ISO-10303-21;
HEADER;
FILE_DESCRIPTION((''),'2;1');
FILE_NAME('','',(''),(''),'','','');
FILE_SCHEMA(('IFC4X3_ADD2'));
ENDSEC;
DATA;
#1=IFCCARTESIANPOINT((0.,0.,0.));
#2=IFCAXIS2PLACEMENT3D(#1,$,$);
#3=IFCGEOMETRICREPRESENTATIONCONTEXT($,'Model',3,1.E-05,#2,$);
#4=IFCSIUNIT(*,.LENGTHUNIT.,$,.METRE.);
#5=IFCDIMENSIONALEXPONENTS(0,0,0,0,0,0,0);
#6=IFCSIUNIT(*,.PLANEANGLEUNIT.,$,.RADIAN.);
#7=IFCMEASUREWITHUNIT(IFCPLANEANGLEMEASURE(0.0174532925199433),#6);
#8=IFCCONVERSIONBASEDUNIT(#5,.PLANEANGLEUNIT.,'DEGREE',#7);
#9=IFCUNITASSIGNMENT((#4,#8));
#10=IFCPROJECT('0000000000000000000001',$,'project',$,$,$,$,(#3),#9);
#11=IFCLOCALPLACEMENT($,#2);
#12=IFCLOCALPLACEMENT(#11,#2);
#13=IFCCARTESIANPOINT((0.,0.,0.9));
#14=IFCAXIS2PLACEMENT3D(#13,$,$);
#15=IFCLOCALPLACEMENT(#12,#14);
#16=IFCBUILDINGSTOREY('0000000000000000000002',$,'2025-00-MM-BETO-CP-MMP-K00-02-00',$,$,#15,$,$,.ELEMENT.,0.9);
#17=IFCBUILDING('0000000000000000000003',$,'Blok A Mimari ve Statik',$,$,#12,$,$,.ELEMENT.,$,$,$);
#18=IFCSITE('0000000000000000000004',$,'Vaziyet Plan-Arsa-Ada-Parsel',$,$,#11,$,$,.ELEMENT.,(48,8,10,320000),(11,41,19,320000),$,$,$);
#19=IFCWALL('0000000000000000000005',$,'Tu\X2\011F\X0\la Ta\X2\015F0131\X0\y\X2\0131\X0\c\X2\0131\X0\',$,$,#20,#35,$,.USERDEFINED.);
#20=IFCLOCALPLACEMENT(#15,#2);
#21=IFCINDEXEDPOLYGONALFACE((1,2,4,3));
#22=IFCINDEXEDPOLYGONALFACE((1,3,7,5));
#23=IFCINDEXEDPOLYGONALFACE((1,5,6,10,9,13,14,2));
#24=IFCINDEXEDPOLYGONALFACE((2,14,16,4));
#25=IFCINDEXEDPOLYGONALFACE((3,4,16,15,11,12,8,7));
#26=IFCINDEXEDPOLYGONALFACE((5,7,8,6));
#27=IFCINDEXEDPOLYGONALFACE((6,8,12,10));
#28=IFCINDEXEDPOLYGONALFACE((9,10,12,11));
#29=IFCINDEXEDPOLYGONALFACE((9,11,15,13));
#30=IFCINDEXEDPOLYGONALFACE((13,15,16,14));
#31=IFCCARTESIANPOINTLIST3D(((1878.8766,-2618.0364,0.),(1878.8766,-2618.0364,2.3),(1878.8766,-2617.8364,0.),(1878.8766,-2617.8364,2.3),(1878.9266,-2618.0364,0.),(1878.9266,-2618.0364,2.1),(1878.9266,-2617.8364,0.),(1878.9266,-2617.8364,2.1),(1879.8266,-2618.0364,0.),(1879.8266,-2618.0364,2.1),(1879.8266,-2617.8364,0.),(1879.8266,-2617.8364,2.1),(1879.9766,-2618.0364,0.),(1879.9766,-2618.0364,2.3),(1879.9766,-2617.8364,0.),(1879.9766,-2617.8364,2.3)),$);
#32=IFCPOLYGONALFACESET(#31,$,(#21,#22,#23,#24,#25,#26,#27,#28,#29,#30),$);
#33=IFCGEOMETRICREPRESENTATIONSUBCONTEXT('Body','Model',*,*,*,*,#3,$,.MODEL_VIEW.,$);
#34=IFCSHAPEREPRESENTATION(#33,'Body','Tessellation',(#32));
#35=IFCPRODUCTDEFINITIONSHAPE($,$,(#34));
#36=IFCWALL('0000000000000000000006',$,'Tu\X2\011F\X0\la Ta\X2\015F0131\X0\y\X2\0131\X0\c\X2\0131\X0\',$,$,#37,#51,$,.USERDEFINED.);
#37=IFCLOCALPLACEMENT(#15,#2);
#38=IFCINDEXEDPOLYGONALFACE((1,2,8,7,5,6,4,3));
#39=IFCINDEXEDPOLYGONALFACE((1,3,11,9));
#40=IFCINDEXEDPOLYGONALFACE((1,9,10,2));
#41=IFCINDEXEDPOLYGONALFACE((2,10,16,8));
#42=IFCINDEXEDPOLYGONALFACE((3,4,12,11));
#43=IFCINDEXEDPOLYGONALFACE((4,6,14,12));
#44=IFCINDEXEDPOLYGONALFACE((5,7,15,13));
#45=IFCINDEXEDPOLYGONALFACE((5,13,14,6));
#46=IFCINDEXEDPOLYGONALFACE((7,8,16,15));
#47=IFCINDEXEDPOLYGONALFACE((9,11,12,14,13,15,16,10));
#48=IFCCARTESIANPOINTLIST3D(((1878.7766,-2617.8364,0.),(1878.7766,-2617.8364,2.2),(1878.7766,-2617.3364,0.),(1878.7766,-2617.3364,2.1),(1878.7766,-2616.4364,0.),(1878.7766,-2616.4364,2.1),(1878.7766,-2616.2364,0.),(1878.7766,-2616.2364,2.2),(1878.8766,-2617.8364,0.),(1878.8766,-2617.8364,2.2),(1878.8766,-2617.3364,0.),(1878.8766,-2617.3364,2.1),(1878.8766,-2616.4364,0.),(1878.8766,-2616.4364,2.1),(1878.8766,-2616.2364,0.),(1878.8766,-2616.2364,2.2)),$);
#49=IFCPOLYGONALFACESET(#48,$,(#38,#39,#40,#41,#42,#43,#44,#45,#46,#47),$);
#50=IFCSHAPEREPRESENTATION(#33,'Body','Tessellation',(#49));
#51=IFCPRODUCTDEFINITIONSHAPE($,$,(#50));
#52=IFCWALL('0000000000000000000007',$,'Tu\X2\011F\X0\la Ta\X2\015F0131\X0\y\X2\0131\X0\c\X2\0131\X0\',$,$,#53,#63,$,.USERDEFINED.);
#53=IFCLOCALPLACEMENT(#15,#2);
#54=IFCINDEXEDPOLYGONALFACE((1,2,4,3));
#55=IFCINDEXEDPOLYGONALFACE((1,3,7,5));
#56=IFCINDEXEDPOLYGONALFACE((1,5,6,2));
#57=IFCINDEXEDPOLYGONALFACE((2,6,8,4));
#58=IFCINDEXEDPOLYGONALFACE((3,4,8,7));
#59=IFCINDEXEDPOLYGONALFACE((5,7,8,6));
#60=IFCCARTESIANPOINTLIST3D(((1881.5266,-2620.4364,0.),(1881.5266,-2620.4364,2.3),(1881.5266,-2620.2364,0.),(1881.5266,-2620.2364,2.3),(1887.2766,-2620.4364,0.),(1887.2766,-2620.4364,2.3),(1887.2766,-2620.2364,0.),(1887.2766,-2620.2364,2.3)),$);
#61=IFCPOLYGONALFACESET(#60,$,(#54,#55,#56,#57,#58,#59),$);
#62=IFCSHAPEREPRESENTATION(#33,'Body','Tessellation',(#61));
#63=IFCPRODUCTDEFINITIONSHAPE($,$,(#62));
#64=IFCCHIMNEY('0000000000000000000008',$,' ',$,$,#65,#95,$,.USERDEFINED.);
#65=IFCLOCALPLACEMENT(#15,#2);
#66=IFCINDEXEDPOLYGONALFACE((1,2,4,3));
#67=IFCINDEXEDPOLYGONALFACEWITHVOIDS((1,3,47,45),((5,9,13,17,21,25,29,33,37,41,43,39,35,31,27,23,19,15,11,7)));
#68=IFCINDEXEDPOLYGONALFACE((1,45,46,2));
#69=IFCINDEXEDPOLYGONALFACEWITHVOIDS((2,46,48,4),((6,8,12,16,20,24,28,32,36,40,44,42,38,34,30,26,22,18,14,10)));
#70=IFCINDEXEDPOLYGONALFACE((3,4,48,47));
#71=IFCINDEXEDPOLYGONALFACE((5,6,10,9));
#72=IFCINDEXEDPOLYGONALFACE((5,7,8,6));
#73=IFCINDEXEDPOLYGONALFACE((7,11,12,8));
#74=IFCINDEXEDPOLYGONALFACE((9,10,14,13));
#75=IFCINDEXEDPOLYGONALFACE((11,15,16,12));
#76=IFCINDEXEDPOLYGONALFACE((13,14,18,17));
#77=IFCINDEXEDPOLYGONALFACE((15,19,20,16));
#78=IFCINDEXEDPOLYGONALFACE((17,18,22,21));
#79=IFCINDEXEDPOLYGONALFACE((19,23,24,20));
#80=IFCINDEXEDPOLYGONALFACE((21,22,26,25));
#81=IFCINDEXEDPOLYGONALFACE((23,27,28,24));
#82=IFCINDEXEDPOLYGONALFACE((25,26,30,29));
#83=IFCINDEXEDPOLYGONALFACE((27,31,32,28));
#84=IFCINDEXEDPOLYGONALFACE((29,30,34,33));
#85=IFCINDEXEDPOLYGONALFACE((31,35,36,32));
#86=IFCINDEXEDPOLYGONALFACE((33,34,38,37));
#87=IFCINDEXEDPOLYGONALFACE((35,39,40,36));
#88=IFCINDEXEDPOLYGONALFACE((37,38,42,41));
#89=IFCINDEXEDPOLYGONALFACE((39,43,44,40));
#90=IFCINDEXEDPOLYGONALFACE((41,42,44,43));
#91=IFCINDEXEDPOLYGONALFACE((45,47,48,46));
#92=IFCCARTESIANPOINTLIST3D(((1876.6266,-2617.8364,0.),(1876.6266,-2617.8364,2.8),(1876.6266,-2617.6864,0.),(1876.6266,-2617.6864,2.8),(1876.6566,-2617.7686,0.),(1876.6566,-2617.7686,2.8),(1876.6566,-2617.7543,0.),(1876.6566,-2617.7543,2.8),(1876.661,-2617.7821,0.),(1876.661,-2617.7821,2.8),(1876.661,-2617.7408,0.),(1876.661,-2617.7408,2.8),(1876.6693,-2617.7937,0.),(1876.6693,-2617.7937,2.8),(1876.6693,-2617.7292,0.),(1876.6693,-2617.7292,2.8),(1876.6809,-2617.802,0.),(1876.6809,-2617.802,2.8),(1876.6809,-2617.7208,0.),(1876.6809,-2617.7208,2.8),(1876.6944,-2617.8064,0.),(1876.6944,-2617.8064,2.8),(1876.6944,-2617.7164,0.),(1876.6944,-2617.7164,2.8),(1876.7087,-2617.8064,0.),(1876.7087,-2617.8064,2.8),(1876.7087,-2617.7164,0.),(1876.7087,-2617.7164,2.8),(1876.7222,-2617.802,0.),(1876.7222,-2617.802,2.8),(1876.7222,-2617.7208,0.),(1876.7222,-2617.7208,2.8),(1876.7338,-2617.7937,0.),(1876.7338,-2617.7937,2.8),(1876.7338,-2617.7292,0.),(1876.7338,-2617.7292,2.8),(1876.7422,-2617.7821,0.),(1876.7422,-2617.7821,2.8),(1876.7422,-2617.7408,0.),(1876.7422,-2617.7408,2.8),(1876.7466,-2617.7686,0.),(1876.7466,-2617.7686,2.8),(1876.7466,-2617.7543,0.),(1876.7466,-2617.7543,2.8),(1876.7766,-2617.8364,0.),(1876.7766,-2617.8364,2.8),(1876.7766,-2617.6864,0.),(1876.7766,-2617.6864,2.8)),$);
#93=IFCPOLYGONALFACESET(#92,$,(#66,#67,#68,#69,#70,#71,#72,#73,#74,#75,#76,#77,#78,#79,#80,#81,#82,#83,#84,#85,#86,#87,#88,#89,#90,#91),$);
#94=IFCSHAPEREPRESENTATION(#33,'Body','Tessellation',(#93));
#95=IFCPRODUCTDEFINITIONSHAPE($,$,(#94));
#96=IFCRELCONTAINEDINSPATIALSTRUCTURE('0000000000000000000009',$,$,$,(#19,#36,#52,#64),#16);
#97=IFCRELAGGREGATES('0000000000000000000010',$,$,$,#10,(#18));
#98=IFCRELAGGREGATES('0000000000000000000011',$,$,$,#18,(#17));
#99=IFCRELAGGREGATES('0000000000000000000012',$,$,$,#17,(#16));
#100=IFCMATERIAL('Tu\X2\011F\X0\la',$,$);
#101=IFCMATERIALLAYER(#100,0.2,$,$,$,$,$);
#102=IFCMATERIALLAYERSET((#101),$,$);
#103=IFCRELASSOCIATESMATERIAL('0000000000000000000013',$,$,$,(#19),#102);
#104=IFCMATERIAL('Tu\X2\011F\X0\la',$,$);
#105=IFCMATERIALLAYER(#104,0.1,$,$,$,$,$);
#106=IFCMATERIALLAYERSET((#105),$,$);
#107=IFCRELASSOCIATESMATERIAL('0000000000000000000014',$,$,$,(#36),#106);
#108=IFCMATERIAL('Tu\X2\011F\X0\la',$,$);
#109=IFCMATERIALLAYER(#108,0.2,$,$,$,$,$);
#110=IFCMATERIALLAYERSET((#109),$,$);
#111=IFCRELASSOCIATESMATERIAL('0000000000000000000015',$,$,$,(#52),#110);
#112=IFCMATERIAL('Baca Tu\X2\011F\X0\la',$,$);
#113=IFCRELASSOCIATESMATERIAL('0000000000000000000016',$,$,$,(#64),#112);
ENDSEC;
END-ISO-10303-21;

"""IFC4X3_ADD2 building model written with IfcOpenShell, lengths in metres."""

from ifc_helpers import new_model, entity, si_unit, converted_unit, frame, frame_2d, origin, origin_with_axes, place, context, subcontext, project, spatial, polyline, rectangle, outline, extrude, material, layer, layer_set, layer_usage, element, save


model = new_model("IFC4X3_ADD2")

# Units and contexts
model_context = context("Model", 3, precision=1e-05, world=origin())
body_context = subcontext(model_context, "Body", "Model", "MODEL_VIEW")
ifc_project = project(units=[si_unit("LENGTHUNIT", "METRE"), converted_unit("PLANEANGLEUNIT", "DEGREE", entity("IfcPlaneAngleMeasure", 0.0174532925199433), si_unit("PLANEANGLEUNIT", "RADIAN"), dimensions=[0, 0, 0, 0, 0, 0, 0])], contexts=[model_context])

# Site, building, storey
site_placement = place(None, origin())
site = spatial("IfcSite", under=ifc_project, at=site_placement, Name="Vaziyet Plan-Arsa-Ada-Parsel", CompositionType="ELEMENT", RefLatitude=(48, 8, 10, 320000), RefLongitude=(11, 41, 19, 320000))
building_placement = place(site_placement, origin())
building = spatial("IfcBuilding", under=site, at=building_placement, Name="Blok A Mimari ve Statik", CompositionType="ELEMENT")
storey_placement = place(building_placement, frame((0.0, 0.0, 0.9)))
storey = spatial("IfcBuildingStorey", under=building, at=storey_placement, Name="2025-00-MM-BETO-CP-MMP-K00-02-00", CompositionType="ELEMENT", Elevation=0.9)

# Wall, opening
ifc_material_1 = material(Name="Tuğla")
ifc_layer_1 = layer(ifc_material_1, 0.2)
ifc_layer_set_1 = layer_set([ifc_layer_1])
ifc_layer_usage_1 = layer_usage(ifc_layer_set_1, "AXIS2", "POSITIVE", 0.0)
wall_1_placement = place(storey_placement, frame((1879.9766, -2617.8364, 0.0), z_axis=(0.0, 0.0, 1.0), x_axis=(-1.0, -0.000002, 0.0)))
wall_1 = element("IfcWall", 1, at=wall_1_placement, inside=storey, material=ifc_layer_usage_1, Name="Tuğla Taşıyıcı", PredefinedType="USERDEFINED", context=body_context, shape_type="SweptSolid", body=[
    extrude(rectangle(XDim=1.1, YDim=0.2, at=frame_2d((0.55, 0.1), x_axis=(1.0, 0.0))), origin_with_axes(), (0.0, 0.0, 1.0), 2.3),
])
opening_1_placement = place(wall_1_placement, frame((0.15, 0.0, 0.0), z_axis=(0.0, 1.0, 0.0), x_axis=(0.0, 0.0, 1.0)))
element("IfcOpeningElement", 2, at=opening_1_placement, cuts=wall_1, PredefinedType="OPENING", context=body_context, shape_type="SweptSolid", body=[
    extrude(outline(polyline([(2.1, 0.9), (2.1, 0.0), (0.0, 0.0), (0.0, 0.9), (2.1, 0.9)])), origin_with_axes(), (0.0, 0.0, 1.0), 0.2),
])

# Wall, openings
ifc_material_2 = material(Name="Tuğla")
ifc_layer_2 = layer(ifc_material_2, 0.1)
ifc_layer_set_2 = layer_set([ifc_layer_2])
ifc_layer_usage_2 = layer_usage(ifc_layer_set_2, "AXIS2", "POSITIVE", 0.0)
wall_2_placement = place(storey_placement, frame((1878.8766, -2617.8364, 0.0), z_axis=(0.0, 0.0, 1.0), x_axis=(0.0, 1.0, 0.0)))
wall_2 = element("IfcWall", 3, at=wall_2_placement, inside=storey, material=ifc_layer_usage_2, Name="Tuğla Taşıyıcı", PredefinedType="USERDEFINED", context=body_context, shape_type="SweptSolid", body=[
    extrude(outline(polyline([(0.0, -0.1), (1.6, -0.1), (1.6, 0.0), (0.0, 0.0), (0.0, -0.1)])), frame((0.0, 0.1, 0.0), z_axis=(0.0, 0.0, 1.0), x_axis=(1.0, 0.0, 0.0)), (0.0, 0.0, 1.0), 2.2),
])
opening_2_placement = place(wall_2_placement, frame((0.5, 0.0, 0.0), z_axis=(0.0, 1.0, 0.0), x_axis=(0.0, 0.0, 1.0)))
element("IfcOpeningElement", 4, at=opening_2_placement, cuts=wall_2, PredefinedType="OPENING", context=body_context, shape_type="SweptSolid", body=[
    extrude(outline(polyline([(2.1, 0.9), (2.1, 0.0), (0.0, 0.0), (0.0, 0.9), (2.1, 0.9)])), origin_with_axes(), (0.0, 0.0, 1.0), 0.1),
])
opening_3_placement = place(wall_2_placement, frame((0.5, 0.0, 0.0), z_axis=(0.0, 1.0, 0.0), x_axis=(0.0, 0.0, 1.0)))
element("IfcOpeningElement", 5, at=opening_3_placement, cuts=wall_2, PredefinedType="OPENING", context=body_context, shape_type="SweptSolid", body=[
    extrude(outline(polyline([(2.1, 0.9), (2.1, 0.0), (0.0, 0.0), (0.0, 0.9), (2.1, 0.9)])), origin_with_axes(), (0.0, 0.0, 1.0), 0.1),
])

# Wall
ifc_material_3 = material(Name="Tuğla")
ifc_layer_3 = layer(ifc_material_3, 0.2)
ifc_layer_set_3 = layer_set([ifc_layer_3])
ifc_layer_usage_3 = layer_usage(ifc_layer_set_3, "AXIS2", "POSITIVE", 0.0)
wall_3_placement = place(storey_placement, frame((1881.5266, -2620.4364, 0.0)))
element("IfcWall", 6, at=wall_3_placement, inside=storey, material=ifc_layer_usage_3, Name="Tuğla Taşıyıcı", PredefinedType="USERDEFINED", context=body_context, shape_type="SweptSolid", body=[
    extrude(rectangle(XDim=5.75, YDim=0.2, at=frame_2d((2.875, 0.1), x_axis=(1.0, 0.0))), origin_with_axes(), (0.0, 0.0, 1.0), 2.3),
])

# Chimney
ifc_material_4 = material(Name="Baca Tuğla")
chimney_placement = place(storey_placement, frame((1876.6266, -2617.8364, 0.0)))
element("IfcChimney", 7, at=chimney_placement, inside=storey, material=ifc_material_4, Name=" ", PredefinedType="USERDEFINED", context=body_context, shape_type="SweptSolid", body=[
    extrude(outline(polyline([(0.0, 0.0), (0.15, 0.0), (0.15, 0.15), (0.0, 0.15), (0.0, 0.0)]), holes=[polyline([(0.1072, 0.0428), (0.0957, 0.0344), (0.0821, 0.03), (0.0679, 0.03), (0.0543, 0.0344), (0.0428, 0.0428), (0.0344, 0.0543), (0.03, 0.0679), (0.03, 0.0821), (0.0344, 0.0957), (0.0428, 0.1072), (0.0543, 0.1156), (0.0679, 0.12), (0.0821, 0.12), (0.0957, 0.1156), (0.1072, 0.1072), (0.1156, 0.0957), (0.12, 0.0821), (0.12, 0.0679), (0.1156, 0.0543), (0.1072, 0.0428)])]), origin_with_axes(), (0.0, 0.0, 1.0), 2.8),
])

save(model, "model.ifc")
